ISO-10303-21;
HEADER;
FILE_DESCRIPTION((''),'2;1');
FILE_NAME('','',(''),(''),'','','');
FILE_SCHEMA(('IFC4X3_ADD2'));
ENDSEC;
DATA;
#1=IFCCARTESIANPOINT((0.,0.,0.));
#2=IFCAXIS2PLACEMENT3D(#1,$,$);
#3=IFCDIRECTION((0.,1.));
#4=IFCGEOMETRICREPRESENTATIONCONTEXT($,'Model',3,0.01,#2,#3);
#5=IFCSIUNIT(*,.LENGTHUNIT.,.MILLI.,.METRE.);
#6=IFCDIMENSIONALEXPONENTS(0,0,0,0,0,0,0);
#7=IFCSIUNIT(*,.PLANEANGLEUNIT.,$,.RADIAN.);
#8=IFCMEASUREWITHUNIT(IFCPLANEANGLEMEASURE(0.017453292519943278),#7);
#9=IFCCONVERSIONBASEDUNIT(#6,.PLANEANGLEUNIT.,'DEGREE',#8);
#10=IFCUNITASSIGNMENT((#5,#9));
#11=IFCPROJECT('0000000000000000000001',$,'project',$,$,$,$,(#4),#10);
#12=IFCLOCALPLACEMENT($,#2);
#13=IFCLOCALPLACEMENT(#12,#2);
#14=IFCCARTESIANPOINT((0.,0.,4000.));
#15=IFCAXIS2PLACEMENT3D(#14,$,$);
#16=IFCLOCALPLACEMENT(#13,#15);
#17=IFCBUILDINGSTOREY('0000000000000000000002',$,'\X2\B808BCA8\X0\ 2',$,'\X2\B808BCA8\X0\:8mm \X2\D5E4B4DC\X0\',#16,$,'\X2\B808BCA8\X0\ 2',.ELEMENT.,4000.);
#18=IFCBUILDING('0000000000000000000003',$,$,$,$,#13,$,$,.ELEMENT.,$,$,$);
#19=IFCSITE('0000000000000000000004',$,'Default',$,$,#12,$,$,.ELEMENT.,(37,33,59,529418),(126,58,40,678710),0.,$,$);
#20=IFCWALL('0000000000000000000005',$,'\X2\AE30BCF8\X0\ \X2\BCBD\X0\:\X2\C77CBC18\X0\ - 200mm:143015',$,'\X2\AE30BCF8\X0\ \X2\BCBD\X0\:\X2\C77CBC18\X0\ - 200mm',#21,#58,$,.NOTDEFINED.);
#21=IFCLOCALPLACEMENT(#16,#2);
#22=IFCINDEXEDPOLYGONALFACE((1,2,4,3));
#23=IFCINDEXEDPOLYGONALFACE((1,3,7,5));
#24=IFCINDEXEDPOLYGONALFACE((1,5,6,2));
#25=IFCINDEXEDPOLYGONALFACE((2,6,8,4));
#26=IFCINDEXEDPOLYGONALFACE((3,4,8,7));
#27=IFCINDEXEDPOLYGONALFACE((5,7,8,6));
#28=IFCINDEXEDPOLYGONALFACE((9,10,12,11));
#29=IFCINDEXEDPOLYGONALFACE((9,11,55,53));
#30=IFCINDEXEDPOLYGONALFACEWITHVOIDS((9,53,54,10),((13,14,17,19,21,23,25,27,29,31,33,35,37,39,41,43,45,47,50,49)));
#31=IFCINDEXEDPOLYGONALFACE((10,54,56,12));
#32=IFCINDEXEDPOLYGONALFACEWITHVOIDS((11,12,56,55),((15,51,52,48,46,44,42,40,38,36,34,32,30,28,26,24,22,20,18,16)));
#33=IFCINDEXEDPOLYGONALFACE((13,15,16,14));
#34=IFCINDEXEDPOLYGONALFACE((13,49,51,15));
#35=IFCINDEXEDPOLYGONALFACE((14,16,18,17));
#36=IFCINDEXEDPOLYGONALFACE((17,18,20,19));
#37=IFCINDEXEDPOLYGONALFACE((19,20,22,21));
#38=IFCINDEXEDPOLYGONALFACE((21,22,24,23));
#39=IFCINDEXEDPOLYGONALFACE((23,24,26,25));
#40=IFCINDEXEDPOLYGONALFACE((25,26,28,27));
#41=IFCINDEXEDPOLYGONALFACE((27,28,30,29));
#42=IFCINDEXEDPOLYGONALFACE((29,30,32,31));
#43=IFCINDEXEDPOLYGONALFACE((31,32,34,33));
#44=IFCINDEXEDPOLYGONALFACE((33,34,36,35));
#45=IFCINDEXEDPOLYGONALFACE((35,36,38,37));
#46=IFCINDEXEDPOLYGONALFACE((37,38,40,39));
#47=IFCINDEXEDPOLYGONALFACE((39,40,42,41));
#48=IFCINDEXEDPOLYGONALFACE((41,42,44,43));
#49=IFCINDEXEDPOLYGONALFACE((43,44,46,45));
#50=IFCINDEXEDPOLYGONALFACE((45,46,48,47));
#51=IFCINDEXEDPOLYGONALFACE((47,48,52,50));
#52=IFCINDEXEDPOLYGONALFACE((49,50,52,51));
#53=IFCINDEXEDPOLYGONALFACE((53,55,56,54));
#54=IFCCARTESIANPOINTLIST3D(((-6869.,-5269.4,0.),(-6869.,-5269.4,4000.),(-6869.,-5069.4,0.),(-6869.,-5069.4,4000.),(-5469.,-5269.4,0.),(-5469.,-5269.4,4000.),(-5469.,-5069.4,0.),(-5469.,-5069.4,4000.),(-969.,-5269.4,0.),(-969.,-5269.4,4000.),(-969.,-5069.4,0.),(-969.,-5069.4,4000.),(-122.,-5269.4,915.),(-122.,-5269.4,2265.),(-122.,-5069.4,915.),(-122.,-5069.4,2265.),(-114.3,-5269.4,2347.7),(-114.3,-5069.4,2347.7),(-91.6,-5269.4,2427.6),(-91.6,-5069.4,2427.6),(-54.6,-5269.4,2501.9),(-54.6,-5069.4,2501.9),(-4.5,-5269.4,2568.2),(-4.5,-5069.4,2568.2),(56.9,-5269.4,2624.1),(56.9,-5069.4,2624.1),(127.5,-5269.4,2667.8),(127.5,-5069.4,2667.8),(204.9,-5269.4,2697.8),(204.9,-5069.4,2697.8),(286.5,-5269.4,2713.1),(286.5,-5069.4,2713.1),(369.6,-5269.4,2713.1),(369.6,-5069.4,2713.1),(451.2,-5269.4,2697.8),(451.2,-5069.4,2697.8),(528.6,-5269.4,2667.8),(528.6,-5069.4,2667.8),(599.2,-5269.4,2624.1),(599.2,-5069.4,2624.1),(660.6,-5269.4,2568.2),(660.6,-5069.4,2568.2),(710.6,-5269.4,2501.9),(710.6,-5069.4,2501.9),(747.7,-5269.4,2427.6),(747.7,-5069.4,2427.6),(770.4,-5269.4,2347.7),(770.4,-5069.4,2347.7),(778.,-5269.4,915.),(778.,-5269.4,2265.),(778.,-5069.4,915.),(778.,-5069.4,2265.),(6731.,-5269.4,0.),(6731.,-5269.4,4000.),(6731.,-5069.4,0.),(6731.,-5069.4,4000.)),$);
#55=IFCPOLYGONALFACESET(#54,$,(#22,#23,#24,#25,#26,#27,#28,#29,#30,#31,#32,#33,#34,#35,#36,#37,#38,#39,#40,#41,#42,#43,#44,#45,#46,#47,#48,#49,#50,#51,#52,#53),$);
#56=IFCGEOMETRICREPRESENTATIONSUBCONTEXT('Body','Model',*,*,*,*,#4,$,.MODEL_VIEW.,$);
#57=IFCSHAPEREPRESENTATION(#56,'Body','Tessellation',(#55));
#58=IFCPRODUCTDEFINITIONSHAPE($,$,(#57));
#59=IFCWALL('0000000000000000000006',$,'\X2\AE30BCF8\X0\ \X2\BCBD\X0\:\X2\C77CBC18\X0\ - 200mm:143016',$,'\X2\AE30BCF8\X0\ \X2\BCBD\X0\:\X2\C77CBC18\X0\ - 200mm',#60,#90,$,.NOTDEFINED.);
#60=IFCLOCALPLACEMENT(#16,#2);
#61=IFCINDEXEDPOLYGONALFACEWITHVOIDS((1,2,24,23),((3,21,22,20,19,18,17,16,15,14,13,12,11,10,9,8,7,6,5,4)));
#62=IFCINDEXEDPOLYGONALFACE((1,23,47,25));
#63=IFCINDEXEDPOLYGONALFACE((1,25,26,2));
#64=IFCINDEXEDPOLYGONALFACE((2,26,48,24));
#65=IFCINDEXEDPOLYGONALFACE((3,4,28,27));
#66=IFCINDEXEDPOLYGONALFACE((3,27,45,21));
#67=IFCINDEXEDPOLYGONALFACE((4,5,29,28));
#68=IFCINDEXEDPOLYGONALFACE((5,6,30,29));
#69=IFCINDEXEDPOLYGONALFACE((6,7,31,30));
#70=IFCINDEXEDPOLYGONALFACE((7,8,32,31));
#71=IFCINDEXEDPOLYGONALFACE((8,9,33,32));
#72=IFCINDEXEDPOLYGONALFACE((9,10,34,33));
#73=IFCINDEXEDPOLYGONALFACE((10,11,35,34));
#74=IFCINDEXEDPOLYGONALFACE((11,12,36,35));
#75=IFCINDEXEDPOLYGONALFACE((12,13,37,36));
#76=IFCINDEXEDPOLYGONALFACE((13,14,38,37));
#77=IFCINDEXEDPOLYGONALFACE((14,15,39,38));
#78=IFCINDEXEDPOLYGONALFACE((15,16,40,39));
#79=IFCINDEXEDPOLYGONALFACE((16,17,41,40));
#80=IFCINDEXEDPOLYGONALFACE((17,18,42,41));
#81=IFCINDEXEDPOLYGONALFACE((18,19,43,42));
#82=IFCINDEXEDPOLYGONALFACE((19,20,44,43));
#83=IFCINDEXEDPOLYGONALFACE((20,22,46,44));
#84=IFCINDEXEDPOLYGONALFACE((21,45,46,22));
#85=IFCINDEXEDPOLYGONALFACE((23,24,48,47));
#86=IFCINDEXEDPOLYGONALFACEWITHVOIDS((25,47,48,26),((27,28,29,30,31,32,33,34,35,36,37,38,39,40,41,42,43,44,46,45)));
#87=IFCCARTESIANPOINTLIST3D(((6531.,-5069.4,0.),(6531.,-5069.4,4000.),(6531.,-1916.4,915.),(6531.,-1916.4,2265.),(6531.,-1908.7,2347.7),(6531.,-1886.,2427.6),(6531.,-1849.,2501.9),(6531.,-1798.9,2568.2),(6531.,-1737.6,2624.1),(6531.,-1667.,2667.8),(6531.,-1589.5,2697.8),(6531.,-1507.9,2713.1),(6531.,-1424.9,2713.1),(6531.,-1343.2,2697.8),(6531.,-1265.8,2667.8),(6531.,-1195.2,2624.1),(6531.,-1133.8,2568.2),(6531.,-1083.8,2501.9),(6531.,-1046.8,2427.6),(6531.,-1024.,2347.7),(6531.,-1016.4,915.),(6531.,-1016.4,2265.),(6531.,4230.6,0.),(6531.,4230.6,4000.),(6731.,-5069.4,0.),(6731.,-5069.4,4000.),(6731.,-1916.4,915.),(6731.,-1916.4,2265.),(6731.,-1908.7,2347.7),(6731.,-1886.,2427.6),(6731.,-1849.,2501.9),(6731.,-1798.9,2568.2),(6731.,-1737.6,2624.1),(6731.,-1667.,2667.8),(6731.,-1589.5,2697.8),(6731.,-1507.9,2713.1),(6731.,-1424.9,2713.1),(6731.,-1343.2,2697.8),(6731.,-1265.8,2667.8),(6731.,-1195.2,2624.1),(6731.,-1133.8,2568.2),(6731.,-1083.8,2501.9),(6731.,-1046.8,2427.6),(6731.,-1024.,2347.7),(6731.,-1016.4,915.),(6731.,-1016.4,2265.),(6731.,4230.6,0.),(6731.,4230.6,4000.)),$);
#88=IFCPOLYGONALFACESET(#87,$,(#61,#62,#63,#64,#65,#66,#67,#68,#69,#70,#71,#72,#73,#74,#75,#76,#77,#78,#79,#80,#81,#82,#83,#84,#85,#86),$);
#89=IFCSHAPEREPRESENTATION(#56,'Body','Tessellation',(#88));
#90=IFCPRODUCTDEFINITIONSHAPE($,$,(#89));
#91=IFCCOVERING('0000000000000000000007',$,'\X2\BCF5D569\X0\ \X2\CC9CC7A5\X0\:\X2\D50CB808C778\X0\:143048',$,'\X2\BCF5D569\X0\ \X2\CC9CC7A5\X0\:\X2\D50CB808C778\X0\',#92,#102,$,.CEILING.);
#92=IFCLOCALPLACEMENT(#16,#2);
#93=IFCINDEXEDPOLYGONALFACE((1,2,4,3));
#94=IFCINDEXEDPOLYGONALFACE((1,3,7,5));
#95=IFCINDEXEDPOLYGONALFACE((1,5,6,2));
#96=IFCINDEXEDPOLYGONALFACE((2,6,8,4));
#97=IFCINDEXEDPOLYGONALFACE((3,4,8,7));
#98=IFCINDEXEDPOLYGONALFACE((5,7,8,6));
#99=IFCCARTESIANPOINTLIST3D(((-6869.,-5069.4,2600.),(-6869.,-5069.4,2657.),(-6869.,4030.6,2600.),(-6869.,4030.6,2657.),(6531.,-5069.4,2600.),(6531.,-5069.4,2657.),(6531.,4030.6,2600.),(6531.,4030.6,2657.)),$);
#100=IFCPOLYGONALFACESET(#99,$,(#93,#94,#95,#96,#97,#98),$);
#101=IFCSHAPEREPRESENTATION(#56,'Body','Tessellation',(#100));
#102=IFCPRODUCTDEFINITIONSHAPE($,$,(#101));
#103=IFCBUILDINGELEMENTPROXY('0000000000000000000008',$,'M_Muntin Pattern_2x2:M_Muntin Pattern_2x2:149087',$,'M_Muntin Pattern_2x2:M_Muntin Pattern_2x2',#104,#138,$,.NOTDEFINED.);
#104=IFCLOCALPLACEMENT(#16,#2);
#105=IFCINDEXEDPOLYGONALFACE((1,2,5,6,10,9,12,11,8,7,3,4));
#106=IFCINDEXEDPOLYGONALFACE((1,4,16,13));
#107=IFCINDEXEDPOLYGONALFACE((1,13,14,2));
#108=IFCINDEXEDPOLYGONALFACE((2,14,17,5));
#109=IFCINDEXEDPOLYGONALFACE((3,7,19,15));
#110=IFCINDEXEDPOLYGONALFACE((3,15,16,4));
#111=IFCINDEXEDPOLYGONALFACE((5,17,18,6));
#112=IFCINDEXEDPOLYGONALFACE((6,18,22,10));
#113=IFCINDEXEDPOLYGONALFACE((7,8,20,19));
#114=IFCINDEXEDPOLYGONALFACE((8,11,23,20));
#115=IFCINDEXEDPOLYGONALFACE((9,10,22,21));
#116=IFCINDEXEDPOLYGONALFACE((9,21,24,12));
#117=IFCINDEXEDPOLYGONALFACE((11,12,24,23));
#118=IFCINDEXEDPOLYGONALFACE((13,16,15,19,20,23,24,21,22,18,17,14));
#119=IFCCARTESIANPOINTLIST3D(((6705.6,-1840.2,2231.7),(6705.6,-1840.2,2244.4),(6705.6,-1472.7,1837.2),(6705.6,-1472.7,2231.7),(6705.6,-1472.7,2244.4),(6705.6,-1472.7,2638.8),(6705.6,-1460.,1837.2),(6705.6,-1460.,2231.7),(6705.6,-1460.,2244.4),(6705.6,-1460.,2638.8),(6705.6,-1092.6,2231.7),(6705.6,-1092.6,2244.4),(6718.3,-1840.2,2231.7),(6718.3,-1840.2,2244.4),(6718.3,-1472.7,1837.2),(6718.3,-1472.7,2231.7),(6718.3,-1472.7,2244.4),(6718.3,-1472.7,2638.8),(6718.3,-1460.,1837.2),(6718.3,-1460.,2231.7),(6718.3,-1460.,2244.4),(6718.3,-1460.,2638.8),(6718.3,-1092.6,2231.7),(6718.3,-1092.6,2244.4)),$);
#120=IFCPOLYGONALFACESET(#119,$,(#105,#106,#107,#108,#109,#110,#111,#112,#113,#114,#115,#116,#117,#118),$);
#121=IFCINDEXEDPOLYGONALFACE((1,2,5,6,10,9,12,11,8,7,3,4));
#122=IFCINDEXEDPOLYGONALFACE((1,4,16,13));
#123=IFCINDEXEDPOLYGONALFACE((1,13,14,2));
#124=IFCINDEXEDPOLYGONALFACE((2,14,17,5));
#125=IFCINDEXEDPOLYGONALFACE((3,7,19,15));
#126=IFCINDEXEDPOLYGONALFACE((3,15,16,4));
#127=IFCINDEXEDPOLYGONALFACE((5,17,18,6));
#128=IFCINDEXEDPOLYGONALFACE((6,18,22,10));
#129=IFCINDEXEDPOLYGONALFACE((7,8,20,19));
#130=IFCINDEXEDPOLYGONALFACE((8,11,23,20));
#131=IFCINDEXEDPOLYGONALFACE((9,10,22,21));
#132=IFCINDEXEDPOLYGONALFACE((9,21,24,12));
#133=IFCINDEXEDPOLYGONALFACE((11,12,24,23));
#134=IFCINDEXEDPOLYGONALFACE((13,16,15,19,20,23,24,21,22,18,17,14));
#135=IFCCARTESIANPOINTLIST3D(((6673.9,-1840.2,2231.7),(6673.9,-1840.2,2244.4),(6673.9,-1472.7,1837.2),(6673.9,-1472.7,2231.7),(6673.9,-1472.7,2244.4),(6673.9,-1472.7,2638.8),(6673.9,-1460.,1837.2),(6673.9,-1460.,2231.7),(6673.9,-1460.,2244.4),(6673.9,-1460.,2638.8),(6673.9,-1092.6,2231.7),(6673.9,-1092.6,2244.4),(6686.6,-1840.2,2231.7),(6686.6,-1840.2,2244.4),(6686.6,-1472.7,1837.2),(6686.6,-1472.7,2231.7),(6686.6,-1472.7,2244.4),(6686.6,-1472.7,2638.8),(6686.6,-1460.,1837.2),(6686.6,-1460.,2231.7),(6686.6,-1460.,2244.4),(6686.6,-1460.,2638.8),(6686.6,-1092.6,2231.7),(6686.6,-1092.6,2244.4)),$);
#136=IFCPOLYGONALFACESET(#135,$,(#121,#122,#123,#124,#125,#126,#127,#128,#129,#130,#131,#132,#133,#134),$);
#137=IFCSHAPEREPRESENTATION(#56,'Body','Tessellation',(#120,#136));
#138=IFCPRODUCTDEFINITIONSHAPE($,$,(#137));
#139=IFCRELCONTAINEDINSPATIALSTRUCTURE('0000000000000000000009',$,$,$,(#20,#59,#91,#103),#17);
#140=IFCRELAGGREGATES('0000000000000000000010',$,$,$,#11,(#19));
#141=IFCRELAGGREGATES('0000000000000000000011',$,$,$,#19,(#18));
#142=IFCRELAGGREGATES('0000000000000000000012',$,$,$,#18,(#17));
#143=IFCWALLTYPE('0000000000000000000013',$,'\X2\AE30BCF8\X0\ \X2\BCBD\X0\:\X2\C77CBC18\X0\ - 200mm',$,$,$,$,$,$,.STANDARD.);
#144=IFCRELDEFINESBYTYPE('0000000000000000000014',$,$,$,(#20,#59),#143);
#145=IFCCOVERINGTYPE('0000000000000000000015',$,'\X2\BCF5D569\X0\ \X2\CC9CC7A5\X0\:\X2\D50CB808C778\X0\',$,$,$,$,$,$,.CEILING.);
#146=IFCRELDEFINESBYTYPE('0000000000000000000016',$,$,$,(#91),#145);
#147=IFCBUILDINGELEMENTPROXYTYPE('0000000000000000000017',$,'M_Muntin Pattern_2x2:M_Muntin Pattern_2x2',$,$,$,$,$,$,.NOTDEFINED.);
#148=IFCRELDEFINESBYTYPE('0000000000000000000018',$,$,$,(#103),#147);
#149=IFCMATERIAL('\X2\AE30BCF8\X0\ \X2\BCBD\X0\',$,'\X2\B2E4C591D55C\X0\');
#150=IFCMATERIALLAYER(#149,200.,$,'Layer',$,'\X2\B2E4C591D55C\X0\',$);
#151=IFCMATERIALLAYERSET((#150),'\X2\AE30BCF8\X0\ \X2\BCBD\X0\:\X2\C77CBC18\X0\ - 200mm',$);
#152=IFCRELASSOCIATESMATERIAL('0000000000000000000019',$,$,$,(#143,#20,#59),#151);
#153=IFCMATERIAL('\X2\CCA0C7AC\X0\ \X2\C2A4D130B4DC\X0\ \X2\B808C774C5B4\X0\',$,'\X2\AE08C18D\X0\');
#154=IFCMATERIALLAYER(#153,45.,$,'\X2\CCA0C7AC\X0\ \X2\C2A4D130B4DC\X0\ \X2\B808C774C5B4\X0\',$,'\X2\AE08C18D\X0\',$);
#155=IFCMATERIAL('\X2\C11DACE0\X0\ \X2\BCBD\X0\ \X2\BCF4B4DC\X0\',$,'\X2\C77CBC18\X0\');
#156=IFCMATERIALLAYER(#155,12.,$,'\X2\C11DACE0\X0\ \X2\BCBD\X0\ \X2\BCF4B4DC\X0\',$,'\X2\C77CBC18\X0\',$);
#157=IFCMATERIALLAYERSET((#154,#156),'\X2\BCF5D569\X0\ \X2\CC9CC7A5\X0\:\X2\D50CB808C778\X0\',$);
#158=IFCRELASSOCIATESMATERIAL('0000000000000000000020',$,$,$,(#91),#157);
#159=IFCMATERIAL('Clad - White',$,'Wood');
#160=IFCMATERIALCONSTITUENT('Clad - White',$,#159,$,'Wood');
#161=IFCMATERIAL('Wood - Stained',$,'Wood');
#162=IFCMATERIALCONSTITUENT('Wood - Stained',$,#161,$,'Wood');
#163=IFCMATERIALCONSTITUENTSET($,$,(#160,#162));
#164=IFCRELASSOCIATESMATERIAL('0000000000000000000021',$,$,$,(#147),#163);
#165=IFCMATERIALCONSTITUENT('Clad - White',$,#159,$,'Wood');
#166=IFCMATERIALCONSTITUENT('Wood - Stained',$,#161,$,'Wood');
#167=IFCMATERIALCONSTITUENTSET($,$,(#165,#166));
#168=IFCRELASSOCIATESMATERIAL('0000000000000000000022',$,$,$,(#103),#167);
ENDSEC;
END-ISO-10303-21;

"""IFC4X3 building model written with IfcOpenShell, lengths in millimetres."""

from ifc_helpers import new_model, entity, si_unit, converted_unit, direction, frame, frame_2d, origin, origin_2d_with_axis, place, context, subcontext, project, spatial, polyline, circle_curve, parameter, trimmed, segment, composite_curve, rectangle, outline, extrude, source, transform, mapped, material, layer, layer_set, layer_usage, constituent, constituent_set, type_object, type_shapes, element, save


model = new_model("IFC4X3")

# Units and contexts
model_context = context("Model", 3, precision=0.01, world=origin(), true_north=direction((0.0, 1.0)))
body_context = subcontext(model_context, "Body", "Model", "MODEL_VIEW")
ifc_project = project(units=[si_unit("LENGTHUNIT", "METRE", prefix="MILLI"), converted_unit("PLANEANGLEUNIT", "DEGREE", entity("IfcPlaneAngleMeasure", 0.017453292519943278), si_unit("PLANEANGLEUNIT", "RADIAN"), dimensions=[0, 0, 0, 0, 0, 0, 0])], contexts=[model_context])

# Site, building, storey
site_placement = place(None, origin())
site = spatial("IfcSite", under=ifc_project, at=site_placement, Name="Default", CompositionType="ELEMENT", RefLatitude=(37, 33, 59, 529418), RefLongitude=(126, 58, 40, 678710), RefElevation=0.0)
building_placement = place(site_placement, origin())
building = spatial("IfcBuilding", under=site, at=building_placement, CompositionType="ELEMENT")
storey_placement = place(building_placement, frame((0.0, 0.0, 4000.0)))
storey = spatial("IfcBuildingStorey", under=building, at=storey_placement, Name="레벨 2", ObjectType="레벨:8mm 헤드", LongName="레벨 2", CompositionType="ELEMENT", Elevation=4000.0)

# Shared definitions
ifc_material_1 = material(Name="기본 벽", Category="다양한")
ifc_layer_1 = layer(ifc_material_1, 200.0, Name="Layer", Category="다양한")
ifc_layer_set_1 = layer_set([ifc_layer_1], Name="기본 벽:일반 - 200mm")
wall_type = type_object("IfcWallType", Name="기본 벽:일반 - 200mm", PredefinedType="STANDARD", material=ifc_layer_set_1)

# Wall, openings
wall_1_placement = place(storey_placement, frame((6731.0, -5169.4, 0.0), z_axis=(0.0, 0.0, 1.0), x_axis=(-1.0, 0.0, 0.0)))
wall_1 = element("IfcWall", 1, at=wall_1_placement, inside=storey, type_object=wall_type, material=ifc_layer_set_1, Name="기본 벽:일반 - 200mm:143015", ObjectType="기본 벽:일반 - 200mm", PredefinedType="NOTDEFINED", context=body_context, shape_type="SweptSolid", body=[
    extrude(rectangle(XDim=200.0, YDim=13600.0, at=frame_2d((6800.0, 0.0), x_axis=(0.0, -1.0))), origin(), (0.0, 0.0, 1.0), 4000.0),
])
opening_1_placement = place(wall_1_placement, frame((12200.0, 252.4, -4000.0)))
element("IfcOpeningElement", 2, at=opening_1_placement, cuts=wall_1, PredefinedType="OPENING", context=body_context, shape_type="SweptSolid", body=[
    extrude(rectangle(XDim=14356.3, YDim=4500.0, at=frame_2d((0.0, 0.0), x_axis=(0.0, 1.0))), frame((-2250.0, -504.8, 7178.2), z_axis=(0.0, 1.0, 0.0), x_axis=(-1.0, 0.0, 0.0)), (0.0, 0.0, 1.0), 504.8),
])
opening_2_placement = place(wall_1_placement, frame((5953.0, -100.0, 915.0)))
element("IfcOpeningElement", 3, at=opening_2_placement, cuts=wall_1, PredefinedType="OPENING", context=body_context, shape_type="SweptSolid", body=[
    extrude(outline(composite_curve([segment(polyline([(1350.0, 900.0), (0.0, 900.0)]), True, "CONTINUOUS"), segment(polyline([(0.0, 900.0), (0.0, 0.0)]), True, "CONTINUOUS"), segment(polyline([(0.0, 0.0), (1350.0, 0.0)]), True, "CONTINUOUS"), segment(trimmed(circle_curve(frame_2d((1350.0, 450.0), x_axis=(0.0, 1.0)), 450.0), [parameter(180.0)], [parameter(0.0)], True, "PARAMETER"), True, "CONTINUOUS")], self_intersect=False)), frame((0.0, 0.0, 0.0), z_axis=(0.0, 1.0, 0.0), x_axis=(0.0, 0.0, 1.0)), (0.0, 0.0, 1.0), 200.0),
])

# Wall, opening
wall_2_placement = place(storey_placement, frame((6631.0, 4230.6, 0.0), z_axis=(0.0, 0.0, 1.0), x_axis=(0.0, -1.0, 0.0)))
wall_2 = element("IfcWall", 4, at=wall_2_placement, inside=storey, type_object=wall_type, material=ifc_layer_set_1, Name="기본 벽:일반 - 200mm:143016", ObjectType="기본 벽:일반 - 200mm", PredefinedType="NOTDEFINED", context=body_context, shape_type="SweptSolid", body=[
    extrude(rectangle(XDim=9300.0, YDim=200.0, at=frame_2d((4650.0, 0.0), x_axis=(-1.0, 0.0))), origin(), (0.0, 0.0, 1.0), 4000.0),
])
opening_3_placement = place(wall_2_placement, frame((5247.0, -100.0, 915.0)))
element("IfcOpeningElement", 5, at=opening_3_placement, cuts=wall_2, PredefinedType="OPENING", context=body_context, shape_type="SweptSolid", body=[
    extrude(outline(composite_curve([segment(polyline([(1350.0, 900.0), (0.0, 900.0)]), True, "CONTINUOUS"), segment(polyline([(0.0, 900.0), (0.0, 0.0)]), True, "CONTINUOUS"), segment(polyline([(0.0, 0.0), (1350.0, 0.0)]), True, "CONTINUOUS"), segment(trimmed(circle_curve(frame_2d((1350.0, 450.0), x_axis=(0.0, 1.0)), 450.0), [parameter(180.0)], [parameter(0.0)], True, "PARAMETER"), True, "CONTINUOUS")], self_intersect=False)), frame((0.0, 0.0, 0.0), z_axis=(0.0, 1.0, 0.0), x_axis=(0.0, 0.0, 1.0)), (0.0, 0.0, 1.0), 200.0),
])

# Covering
ifc_material_2 = material(Name="철재 스터드 레이어", Category="금속")
ifc_layer_2 = layer(ifc_material_2, 45.0, Name="철재 스터드 레이어", Category="금속")
ifc_material_3 = material(Name="석고 벽 보드", Category="일반")
ifc_layer_3 = layer(ifc_material_3, 12.0, Name="석고 벽 보드", Category="일반")
ifc_layer_set_2 = layer_set([ifc_layer_2, ifc_layer_3], Name="복합 천장:플레인")
ifc_layer_usage_1 = layer_usage(ifc_layer_set_2, "AXIS3", "NEGATIVE", 0.0)
covering_type = type_object("IfcCoveringType", Name="복합 천장:플레인", PredefinedType="CEILING")
covering_placement = place(storey_placement, frame((-6869.0, -5069.4, 2600.0)))
element("IfcCovering", 6, at=covering_placement, inside=storey, type_object=covering_type, material=ifc_layer_usage_1, Name="복합 천장:플레인:143048", ObjectType="복합 천장:플레인", PredefinedType="CEILING", context=body_context, shape_type="SweptSolid", body=[
    extrude(rectangle(XDim=9100.0, YDim=13400.0, at=origin_2d_with_axis()), frame((6700.0, 4550.0, 0.0), z_axis=(0.0, 0.0, 1.0), x_axis=(0.0, -1.0, 0.0)), (0.0, 0.0, 1.0), 57.0),
])

# Building element proxy
ifc_material_4 = material(Name="Clad - White", Category="Wood")
ifc_constituent_1 = constituent(ifc_material_4, Name="Clad - White", Category="Wood")
ifc_material_5 = material(Name="Wood - Stained", Category="Wood")
ifc_constituent_2 = constituent(ifc_material_5, Name="Wood - Stained", Category="Wood")
ifc_constituent_set_1 = constituent_set(constituents=[ifc_constituent_1, ifc_constituent_2])
ifc_constituent_3 = constituent(ifc_material_4, Name="Clad - White", Category="Wood")
ifc_constituent_4 = constituent(ifc_material_5, Name="Wood - Stained", Category="Wood")
ifc_constituent_set_2 = constituent_set(constituents=[ifc_constituent_3, ifc_constituent_4])
building_element_proxy_type_1 = type_object("IfcBuildingElementProxyType", Name="M_Muntin Pattern_2x2:M_Muntin Pattern_2x2", PredefinedType="NOTDEFINED", material=ifc_constituent_set_2)
shared_shape_1 = source(origin(), body_context, "Body", "SweptSolid", [
    extrude(outline(polyline([(6.4, -6.4), (400.8, -6.4), (400.8, 6.3), (6.4, 6.3), (6.4, 373.8), (-6.3, 373.8), (-6.3, 6.3), (-400.8, 6.3), (-400.8, -6.4), (-6.3, -6.4), (-6.3, -373.8), (6.4, -373.8), (6.4, -6.4)])), frame((0.0, 9.5, 400.8), z_axis=(0.0, 1.0, 0.0), x_axis=(0.0, 0.0, 1.0)), (0.0, 0.0, 1.0), 12.7),
    extrude(outline(polyline([(6.4, -6.4), (400.8, -6.4), (400.8, 6.3), (6.4, 6.3), (6.4, 373.8), (-6.3, 373.8), (-6.3, 6.3), (-400.8, 6.3), (-400.8, -6.4), (-6.3, -6.4), (-6.3, -373.8), (6.4, -373.8), (6.4, -6.4)])), frame((0.0, -22.2, 400.8), z_axis=(0.0, 1.0, 0.0), x_axis=(0.0, 0.0, 1.0)), (0.0, 0.0, 1.0), 12.7),
])
type_shapes(building_element_proxy_type_1, [shared_shape_1])
proxy_1_placement = place(storey_placement, frame((6696.1, -1466.4, 1837.2), z_axis=(0.0, 0.0, 1.0), x_axis=(0.0, -1.0, 0.0)))
element("IfcBuildingElementProxy", 7, at=proxy_1_placement, inside=storey, type_object=building_element_proxy_type_1, material=ifc_constituent_set_1, Name="M_Muntin Pattern_2x2:M_Muntin Pattern_2x2:149087", ObjectType="M_Muntin Pattern_2x2:M_Muntin Pattern_2x2", PredefinedType="NOTDEFINED", context=body_context, shape_type="MappedRepresentation", body=[
    mapped(shared_shape_1, transform((0.0, 0.0, 0.0), scale=1.0)),
])

save(model, "model.ifc")
